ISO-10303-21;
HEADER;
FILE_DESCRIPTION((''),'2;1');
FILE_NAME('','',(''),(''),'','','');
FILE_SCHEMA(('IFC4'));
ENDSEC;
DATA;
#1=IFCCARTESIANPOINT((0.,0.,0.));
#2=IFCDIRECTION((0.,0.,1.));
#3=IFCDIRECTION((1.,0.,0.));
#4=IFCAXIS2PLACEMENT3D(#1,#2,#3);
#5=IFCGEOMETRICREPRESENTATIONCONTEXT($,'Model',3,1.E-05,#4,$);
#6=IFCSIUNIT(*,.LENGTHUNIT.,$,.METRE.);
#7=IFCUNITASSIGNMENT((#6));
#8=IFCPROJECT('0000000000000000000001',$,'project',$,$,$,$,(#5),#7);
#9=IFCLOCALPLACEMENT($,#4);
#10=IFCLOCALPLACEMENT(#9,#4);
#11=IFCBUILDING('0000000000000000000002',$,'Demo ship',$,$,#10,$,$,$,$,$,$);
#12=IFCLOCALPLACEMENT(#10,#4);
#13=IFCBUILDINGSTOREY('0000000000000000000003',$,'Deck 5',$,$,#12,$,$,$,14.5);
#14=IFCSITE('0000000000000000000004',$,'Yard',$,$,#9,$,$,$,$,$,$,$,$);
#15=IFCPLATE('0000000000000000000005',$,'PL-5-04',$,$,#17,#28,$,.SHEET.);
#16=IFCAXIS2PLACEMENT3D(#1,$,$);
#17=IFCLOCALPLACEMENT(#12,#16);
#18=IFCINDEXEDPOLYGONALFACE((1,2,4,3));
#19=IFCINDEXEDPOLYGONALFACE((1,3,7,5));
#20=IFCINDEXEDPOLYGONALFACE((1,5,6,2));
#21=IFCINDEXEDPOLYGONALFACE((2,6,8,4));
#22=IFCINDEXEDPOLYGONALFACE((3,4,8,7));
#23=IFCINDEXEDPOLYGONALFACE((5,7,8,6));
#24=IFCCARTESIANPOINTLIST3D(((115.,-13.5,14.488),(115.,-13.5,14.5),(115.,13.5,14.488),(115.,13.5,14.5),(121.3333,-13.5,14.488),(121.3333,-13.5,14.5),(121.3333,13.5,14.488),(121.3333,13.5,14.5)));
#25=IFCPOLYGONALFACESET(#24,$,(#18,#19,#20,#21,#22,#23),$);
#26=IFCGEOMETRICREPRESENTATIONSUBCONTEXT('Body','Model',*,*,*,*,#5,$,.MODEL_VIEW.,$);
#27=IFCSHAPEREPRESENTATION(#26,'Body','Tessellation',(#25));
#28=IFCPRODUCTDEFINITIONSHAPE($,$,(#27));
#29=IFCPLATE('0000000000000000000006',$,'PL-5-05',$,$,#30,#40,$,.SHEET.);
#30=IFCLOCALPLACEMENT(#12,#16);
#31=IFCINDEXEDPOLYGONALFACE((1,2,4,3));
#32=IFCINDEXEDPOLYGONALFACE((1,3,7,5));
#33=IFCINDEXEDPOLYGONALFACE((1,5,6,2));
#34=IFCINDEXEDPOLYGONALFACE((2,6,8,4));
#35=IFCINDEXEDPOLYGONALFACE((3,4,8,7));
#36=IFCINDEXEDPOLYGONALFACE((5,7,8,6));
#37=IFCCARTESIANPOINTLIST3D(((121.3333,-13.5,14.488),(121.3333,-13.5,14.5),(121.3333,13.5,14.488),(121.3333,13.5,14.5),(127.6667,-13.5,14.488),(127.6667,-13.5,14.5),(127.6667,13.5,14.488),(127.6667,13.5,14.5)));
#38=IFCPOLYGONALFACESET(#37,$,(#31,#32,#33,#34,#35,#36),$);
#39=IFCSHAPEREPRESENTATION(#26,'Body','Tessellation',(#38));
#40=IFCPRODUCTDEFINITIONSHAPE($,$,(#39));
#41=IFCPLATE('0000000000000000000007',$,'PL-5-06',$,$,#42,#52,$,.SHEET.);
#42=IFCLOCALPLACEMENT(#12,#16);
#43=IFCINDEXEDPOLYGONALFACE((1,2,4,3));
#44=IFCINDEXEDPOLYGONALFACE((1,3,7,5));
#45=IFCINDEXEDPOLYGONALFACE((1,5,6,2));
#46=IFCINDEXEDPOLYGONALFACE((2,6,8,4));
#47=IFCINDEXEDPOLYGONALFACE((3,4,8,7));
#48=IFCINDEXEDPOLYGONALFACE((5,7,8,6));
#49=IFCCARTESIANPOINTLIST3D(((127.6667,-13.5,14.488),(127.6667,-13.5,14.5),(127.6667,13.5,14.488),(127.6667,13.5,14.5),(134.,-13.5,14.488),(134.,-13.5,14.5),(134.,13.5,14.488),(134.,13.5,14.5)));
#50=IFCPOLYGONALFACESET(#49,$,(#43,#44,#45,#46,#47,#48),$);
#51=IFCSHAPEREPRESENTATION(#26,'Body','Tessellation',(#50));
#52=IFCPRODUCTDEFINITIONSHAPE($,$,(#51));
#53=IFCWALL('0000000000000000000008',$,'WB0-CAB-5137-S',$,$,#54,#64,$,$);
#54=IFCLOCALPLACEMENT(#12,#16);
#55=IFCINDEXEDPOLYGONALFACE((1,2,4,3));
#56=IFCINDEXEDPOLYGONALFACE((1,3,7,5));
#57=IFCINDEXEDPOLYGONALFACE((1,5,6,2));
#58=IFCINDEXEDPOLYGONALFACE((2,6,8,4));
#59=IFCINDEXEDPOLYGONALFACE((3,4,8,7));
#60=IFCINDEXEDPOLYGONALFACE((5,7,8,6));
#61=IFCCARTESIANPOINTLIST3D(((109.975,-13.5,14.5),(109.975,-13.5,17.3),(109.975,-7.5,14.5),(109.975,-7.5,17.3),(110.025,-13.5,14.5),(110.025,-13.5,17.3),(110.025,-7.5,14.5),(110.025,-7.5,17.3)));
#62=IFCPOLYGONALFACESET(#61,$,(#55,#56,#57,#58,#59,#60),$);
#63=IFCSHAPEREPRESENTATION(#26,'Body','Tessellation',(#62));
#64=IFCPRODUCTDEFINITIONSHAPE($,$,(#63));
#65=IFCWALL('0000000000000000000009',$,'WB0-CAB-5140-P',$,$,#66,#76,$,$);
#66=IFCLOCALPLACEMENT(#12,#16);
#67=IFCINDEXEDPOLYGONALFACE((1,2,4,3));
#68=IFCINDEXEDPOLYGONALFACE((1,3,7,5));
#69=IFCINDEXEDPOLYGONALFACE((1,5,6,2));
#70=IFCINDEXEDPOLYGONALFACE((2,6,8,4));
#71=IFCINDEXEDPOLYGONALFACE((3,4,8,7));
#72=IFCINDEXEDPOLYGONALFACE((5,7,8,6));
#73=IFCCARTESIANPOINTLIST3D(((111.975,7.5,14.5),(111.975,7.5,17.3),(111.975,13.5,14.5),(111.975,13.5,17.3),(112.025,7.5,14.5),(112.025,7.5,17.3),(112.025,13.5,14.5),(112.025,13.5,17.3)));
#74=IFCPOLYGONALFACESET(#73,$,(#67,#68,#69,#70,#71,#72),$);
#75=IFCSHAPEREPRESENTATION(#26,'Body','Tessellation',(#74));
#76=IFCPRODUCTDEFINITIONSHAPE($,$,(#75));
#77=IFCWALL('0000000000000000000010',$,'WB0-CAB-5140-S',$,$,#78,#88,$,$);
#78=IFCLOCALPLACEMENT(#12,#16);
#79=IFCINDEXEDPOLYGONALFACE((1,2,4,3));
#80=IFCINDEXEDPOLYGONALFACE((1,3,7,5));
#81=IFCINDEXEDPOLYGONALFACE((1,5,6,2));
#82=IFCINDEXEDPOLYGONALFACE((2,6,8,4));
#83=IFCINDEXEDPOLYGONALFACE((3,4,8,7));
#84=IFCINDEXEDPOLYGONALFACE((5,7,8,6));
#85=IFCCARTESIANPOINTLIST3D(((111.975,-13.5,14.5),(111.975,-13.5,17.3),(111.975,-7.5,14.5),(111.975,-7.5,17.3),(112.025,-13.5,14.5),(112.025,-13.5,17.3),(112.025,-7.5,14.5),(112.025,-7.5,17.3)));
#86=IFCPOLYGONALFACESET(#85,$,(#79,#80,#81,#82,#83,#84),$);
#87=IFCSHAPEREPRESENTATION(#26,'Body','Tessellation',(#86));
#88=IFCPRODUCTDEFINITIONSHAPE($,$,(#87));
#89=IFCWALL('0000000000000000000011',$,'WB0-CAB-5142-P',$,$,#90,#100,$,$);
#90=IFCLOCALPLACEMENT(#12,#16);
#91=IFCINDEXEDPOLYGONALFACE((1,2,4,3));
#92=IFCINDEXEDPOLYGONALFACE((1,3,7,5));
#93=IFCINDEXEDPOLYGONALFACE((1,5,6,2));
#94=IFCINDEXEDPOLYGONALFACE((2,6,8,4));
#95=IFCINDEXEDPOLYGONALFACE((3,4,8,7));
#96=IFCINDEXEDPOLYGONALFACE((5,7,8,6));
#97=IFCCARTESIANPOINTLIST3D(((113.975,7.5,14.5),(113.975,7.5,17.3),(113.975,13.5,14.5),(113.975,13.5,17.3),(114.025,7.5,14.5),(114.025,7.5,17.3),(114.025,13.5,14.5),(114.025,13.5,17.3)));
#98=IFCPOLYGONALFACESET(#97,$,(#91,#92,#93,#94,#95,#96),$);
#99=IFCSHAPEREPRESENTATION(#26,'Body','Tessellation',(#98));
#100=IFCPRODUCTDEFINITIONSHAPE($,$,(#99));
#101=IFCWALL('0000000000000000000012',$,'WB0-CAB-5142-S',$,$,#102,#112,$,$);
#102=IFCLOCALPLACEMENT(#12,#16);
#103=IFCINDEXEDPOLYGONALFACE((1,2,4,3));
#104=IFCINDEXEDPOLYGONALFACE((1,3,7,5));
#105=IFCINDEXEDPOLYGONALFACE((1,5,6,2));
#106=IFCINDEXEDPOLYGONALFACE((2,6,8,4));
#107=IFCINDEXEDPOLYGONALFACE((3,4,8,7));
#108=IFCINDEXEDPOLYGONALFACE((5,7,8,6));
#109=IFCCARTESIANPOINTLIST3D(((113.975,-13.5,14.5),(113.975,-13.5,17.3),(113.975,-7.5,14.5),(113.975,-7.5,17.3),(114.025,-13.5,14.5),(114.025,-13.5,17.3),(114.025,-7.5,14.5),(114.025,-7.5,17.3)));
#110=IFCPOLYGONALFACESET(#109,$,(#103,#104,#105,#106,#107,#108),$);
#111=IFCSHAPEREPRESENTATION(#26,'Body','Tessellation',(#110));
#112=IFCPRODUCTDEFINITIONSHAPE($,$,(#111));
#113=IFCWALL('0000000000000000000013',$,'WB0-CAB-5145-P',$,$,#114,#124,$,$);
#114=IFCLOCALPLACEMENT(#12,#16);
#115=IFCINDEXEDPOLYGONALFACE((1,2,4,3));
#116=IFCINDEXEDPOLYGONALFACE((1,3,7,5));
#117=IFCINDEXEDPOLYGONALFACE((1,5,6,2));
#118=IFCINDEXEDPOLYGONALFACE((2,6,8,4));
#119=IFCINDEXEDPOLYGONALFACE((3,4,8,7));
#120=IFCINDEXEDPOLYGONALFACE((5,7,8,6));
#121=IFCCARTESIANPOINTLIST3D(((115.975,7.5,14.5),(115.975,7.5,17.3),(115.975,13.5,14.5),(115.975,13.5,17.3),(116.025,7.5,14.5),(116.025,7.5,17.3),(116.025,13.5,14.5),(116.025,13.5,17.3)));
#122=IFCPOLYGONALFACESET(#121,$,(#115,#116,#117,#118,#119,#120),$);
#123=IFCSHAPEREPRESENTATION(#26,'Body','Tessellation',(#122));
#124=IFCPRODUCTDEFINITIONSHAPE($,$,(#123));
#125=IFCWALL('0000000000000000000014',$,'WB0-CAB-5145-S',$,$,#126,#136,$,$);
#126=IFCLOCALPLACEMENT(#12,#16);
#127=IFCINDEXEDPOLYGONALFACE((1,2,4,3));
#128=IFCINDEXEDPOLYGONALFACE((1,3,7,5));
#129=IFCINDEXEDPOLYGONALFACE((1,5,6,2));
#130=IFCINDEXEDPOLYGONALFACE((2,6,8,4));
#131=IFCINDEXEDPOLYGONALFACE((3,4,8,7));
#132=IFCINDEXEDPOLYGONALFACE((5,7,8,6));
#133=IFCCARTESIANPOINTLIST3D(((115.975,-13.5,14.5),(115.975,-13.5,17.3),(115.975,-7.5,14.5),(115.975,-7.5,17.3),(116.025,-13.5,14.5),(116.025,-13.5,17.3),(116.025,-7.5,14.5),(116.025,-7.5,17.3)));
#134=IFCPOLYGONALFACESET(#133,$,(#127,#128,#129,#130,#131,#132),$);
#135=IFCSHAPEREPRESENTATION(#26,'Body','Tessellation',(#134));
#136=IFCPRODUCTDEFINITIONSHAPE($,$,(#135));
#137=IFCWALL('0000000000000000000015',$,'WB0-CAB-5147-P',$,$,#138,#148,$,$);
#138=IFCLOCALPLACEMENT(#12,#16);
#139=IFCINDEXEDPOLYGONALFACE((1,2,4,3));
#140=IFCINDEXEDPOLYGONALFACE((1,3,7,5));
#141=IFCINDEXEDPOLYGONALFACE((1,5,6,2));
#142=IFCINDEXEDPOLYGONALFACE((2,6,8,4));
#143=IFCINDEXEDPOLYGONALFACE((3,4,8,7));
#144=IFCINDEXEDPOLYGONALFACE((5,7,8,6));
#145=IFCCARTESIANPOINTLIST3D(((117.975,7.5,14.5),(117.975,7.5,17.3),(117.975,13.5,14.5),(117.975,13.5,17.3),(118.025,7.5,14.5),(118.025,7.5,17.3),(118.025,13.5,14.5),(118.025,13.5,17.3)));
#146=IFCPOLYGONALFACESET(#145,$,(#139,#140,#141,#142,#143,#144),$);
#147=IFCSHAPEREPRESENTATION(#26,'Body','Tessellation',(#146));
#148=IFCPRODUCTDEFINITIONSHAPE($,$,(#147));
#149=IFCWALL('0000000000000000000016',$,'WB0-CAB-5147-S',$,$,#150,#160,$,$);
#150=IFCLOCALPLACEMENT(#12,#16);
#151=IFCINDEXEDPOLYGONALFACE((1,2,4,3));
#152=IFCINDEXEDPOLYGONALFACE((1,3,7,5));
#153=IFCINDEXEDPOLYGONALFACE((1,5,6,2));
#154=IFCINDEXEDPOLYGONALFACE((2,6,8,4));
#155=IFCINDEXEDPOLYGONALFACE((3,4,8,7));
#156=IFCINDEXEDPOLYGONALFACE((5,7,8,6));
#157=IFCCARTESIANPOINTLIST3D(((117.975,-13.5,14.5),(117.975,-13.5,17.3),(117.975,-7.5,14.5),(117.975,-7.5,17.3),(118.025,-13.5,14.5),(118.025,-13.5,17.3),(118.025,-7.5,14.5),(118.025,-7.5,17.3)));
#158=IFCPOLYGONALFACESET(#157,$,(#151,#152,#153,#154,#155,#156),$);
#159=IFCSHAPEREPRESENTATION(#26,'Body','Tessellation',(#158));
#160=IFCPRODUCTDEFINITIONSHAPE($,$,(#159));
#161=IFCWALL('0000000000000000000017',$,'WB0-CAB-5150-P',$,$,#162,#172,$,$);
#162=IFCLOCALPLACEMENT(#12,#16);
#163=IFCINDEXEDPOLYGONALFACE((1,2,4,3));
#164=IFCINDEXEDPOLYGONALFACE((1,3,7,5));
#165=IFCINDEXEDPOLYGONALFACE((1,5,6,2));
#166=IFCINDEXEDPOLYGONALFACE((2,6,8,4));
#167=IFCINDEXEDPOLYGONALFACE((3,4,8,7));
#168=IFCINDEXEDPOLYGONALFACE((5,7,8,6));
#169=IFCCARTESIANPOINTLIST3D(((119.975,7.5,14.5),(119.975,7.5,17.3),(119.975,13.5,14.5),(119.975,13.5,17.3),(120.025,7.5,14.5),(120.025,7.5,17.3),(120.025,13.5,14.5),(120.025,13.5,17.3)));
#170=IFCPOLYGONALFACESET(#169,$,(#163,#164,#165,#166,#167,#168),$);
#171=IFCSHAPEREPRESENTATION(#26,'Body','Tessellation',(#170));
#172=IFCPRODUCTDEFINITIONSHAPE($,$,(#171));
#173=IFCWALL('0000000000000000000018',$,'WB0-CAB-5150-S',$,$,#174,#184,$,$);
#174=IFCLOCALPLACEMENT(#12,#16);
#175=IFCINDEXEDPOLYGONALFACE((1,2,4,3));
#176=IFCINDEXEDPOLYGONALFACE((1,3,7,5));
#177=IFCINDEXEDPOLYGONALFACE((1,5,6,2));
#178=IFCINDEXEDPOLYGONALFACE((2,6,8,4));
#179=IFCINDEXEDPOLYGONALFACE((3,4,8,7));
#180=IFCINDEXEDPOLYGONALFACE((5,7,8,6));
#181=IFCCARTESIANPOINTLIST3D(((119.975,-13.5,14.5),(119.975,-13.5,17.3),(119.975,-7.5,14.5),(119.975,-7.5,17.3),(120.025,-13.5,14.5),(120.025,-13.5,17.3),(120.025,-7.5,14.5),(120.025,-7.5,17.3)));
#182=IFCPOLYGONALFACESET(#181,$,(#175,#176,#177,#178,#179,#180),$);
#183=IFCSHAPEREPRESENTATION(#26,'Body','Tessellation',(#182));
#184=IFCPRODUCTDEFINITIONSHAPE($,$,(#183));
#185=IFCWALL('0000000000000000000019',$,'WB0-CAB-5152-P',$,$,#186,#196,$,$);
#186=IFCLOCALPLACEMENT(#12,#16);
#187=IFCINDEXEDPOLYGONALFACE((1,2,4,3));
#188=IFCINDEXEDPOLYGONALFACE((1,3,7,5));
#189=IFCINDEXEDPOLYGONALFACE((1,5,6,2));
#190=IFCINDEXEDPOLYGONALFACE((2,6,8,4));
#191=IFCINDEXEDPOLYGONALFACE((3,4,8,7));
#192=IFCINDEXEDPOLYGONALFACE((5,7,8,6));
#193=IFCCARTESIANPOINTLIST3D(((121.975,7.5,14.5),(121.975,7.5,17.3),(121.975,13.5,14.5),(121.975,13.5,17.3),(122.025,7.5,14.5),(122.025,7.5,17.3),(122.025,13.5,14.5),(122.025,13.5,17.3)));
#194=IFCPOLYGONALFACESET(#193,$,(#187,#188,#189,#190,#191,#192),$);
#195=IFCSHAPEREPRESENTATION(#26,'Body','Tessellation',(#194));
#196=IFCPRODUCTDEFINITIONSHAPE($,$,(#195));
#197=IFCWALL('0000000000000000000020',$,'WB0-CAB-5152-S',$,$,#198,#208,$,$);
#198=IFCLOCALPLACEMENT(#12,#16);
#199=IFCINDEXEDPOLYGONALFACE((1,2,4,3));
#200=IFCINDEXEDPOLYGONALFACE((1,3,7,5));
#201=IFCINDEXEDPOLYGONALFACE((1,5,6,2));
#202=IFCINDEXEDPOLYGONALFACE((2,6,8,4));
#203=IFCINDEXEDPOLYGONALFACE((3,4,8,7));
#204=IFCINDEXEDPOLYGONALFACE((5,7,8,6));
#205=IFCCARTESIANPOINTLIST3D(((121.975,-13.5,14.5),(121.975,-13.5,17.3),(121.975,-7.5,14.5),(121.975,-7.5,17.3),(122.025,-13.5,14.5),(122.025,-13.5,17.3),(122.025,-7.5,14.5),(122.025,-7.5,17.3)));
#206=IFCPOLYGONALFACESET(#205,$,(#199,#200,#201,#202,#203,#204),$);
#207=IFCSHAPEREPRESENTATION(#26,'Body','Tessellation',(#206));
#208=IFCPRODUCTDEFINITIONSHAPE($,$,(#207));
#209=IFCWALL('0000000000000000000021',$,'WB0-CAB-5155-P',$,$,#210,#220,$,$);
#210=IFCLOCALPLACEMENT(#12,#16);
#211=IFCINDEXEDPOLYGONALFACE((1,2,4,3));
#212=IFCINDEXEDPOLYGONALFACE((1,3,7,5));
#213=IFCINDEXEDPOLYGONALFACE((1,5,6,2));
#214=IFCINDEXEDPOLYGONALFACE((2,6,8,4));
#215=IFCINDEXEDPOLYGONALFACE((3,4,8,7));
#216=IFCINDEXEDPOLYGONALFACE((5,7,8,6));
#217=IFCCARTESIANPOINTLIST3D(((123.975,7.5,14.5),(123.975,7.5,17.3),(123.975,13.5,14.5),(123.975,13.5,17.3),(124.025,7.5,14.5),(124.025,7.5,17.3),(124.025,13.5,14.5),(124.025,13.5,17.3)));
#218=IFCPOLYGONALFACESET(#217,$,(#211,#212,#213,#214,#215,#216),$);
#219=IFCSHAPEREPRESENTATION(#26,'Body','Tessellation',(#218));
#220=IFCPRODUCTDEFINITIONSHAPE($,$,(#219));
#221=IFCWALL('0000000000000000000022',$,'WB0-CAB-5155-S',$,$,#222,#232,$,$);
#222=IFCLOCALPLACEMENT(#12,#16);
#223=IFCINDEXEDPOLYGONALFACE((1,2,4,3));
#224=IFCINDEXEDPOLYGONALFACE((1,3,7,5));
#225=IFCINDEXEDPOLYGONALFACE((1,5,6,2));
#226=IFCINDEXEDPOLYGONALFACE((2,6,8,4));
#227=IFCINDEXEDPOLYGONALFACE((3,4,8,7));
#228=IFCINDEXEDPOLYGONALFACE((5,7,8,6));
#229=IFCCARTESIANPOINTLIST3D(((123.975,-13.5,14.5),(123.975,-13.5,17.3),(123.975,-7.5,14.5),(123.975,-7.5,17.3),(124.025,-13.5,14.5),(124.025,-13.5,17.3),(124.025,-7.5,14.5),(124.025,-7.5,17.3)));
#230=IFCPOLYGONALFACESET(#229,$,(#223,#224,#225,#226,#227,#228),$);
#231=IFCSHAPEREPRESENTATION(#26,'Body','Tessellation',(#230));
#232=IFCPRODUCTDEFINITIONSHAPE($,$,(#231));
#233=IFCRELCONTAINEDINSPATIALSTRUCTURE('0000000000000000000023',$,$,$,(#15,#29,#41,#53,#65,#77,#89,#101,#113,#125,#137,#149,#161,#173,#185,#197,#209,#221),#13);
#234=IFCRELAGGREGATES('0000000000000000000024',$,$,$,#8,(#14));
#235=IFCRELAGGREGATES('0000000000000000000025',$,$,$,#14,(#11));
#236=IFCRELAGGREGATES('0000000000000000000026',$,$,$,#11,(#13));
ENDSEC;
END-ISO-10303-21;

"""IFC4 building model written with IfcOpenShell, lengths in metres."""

from ifc_helpers import new_model, si_unit, frame, frame_2d, origin, origin_with_axes, place, context, subcontext, project, spatial, rectangle, extrude, element, save


model = new_model("IFC4")

# Units and contexts
model_context = context("Model", 3, precision=1e-05, world=origin_with_axes())
body_context = subcontext(model_context, "Body", "Model", "MODEL_VIEW")
ifc_project = project(units=[si_unit("LENGTHUNIT", "METRE")], contexts=[model_context])

# Site, building, storey
site_placement = place(None, origin_with_axes())
site = spatial("IfcSite", under=ifc_project, at=site_placement, Name="Yard")
building_placement = place(site_placement, origin_with_axes())
building = spatial("IfcBuilding", under=site, at=building_placement, Name="Demo ship")
storey_placement = place(building_placement, origin_with_axes())
storey = spatial("IfcBuildingStorey", under=building, at=storey_placement, Name="Deck 5", Elevation=14.5)

# Plates
plate_1_placement = place(storey_placement, frame((115.0, -13.5, 14.488), z_axis=(0.0, 0.0, 1.0), x_axis=(1.0, 0.0, 0.0)))
element("IfcPlate", 1, at=plate_1_placement, inside=storey, Name="PL-5-04", PredefinedType="SHEET", context=body_context, shape_type="SweptSolid", body=[
    extrude(rectangle(XDim=6.3333, YDim=27.0, at=frame_2d((3.1666, 13.5))), origin(), (0.0, 0.0, 1.0), 0.012),
])
plate_2_placement = place(storey_placement, frame((121.3333, -13.5, 14.488), z_axis=(0.0, 0.0, 1.0), x_axis=(1.0, 0.0, 0.0)))
element("IfcPlate", 2, at=plate_2_placement, inside=storey, Name="PL-5-05", PredefinedType="SHEET", context=body_context, shape_type="SweptSolid", body=[
    extrude(rectangle(XDim=6.3334, YDim=27.0, at=frame_2d((3.1667, 13.5))), origin(), (0.0, 0.0, 1.0), 0.012),
])
plate_3_placement = place(storey_placement, frame((127.6667, -13.5, 14.488), z_axis=(0.0, 0.0, 1.0), x_axis=(1.0, 0.0, 0.0)))
element("IfcPlate", 3, at=plate_3_placement, inside=storey, Name="PL-5-06", PredefinedType="SHEET", context=body_context, shape_type="SweptSolid", body=[
    extrude(rectangle(XDim=6.3333, YDim=27.0, at=frame_2d((3.1666, 13.5))), origin(), (0.0, 0.0, 1.0), 0.012),
])

# Walls
for number, where, z_axis, x_axis, name in (
    (4, (109.975, -13.5, 14.5), (0.0, 0.0, 1.0), (1.0, 0.0, 0.0), "WB0-CAB-5137-S"),
    (5, (111.975, 7.5, 14.5), (0.0, 0.0, 1.0), (1.0, 0.0, 0.0), "WB0-CAB-5140-P"),
    (6, (111.975, -13.5, 14.5), (0.0, 0.0, 1.0), (1.0, 0.0, 0.0), "WB0-CAB-5140-S"),
    (7, (113.975, 7.5, 14.5), (0.0, 0.0, 1.0), (1.0, 0.0, 0.0), "WB0-CAB-5142-P"),
    (8, (113.975, -13.5, 14.5), (0.0, 0.0, 1.0), (1.0, 0.0, 0.0), "WB0-CAB-5142-S"),
    (9, (115.975, 7.5, 14.5), (0.0, 0.0, 1.0), (1.0, 0.0, 0.0), "WB0-CAB-5145-P"),
    (10, (115.975, -13.5, 14.5), (0.0, 0.0, 1.0), (1.0, 0.0, 0.0), "WB0-CAB-5145-S"),
    (11, (117.975, 7.5, 14.5), (0.0, 0.0, 1.0), (1.0, 0.0, 0.0), "WB0-CAB-5147-P"),
    (12, (117.975, -13.5, 14.5), (0.0, 0.0, 1.0), (1.0, 0.0, 0.0), "WB0-CAB-5147-S"),
    (13, (119.975, 7.5, 14.5), (0.0, 0.0, 1.0), (1.0, 0.0, 0.0), "WB0-CAB-5150-P"),
    (14, (119.975, -13.5, 14.5), (0.0, 0.0, 1.0), (1.0, 0.0, 0.0), "WB0-CAB-5150-S"),
    (15, (121.975, 7.5, 14.5), (0.0, 0.0, 1.0), (1.0, 0.0, 0.0), "WB0-CAB-5152-P"),
    (16, (121.975, -13.5, 14.5), (0.0, 0.0, 1.0), (1.0, 0.0, 0.0), "WB0-CAB-5152-S"),
    (17, (123.975, 7.5, 14.5), (0.0, 0.0, 1.0), (1.0, 0.0, 0.0), "WB0-CAB-5155-P"),
    (18, (123.975, -13.5, 14.5), (0.0, 0.0, 1.0), (1.0, 0.0, 0.0), "WB0-CAB-5155-S"),
):
    element("IfcWall", number, at=place(storey_placement, frame(where, z_axis=z_axis, x_axis=x_axis)), inside=storey, Name=name, context=body_context, shape_type="SweptSolid", body=[
        extrude(rectangle(XDim=0.05, YDim=6.0, at=frame_2d((0.025, 3.0))), origin(), (0.0, 0.0, 1.0), 2.8),
    ])

save(model, "model.ifc")
